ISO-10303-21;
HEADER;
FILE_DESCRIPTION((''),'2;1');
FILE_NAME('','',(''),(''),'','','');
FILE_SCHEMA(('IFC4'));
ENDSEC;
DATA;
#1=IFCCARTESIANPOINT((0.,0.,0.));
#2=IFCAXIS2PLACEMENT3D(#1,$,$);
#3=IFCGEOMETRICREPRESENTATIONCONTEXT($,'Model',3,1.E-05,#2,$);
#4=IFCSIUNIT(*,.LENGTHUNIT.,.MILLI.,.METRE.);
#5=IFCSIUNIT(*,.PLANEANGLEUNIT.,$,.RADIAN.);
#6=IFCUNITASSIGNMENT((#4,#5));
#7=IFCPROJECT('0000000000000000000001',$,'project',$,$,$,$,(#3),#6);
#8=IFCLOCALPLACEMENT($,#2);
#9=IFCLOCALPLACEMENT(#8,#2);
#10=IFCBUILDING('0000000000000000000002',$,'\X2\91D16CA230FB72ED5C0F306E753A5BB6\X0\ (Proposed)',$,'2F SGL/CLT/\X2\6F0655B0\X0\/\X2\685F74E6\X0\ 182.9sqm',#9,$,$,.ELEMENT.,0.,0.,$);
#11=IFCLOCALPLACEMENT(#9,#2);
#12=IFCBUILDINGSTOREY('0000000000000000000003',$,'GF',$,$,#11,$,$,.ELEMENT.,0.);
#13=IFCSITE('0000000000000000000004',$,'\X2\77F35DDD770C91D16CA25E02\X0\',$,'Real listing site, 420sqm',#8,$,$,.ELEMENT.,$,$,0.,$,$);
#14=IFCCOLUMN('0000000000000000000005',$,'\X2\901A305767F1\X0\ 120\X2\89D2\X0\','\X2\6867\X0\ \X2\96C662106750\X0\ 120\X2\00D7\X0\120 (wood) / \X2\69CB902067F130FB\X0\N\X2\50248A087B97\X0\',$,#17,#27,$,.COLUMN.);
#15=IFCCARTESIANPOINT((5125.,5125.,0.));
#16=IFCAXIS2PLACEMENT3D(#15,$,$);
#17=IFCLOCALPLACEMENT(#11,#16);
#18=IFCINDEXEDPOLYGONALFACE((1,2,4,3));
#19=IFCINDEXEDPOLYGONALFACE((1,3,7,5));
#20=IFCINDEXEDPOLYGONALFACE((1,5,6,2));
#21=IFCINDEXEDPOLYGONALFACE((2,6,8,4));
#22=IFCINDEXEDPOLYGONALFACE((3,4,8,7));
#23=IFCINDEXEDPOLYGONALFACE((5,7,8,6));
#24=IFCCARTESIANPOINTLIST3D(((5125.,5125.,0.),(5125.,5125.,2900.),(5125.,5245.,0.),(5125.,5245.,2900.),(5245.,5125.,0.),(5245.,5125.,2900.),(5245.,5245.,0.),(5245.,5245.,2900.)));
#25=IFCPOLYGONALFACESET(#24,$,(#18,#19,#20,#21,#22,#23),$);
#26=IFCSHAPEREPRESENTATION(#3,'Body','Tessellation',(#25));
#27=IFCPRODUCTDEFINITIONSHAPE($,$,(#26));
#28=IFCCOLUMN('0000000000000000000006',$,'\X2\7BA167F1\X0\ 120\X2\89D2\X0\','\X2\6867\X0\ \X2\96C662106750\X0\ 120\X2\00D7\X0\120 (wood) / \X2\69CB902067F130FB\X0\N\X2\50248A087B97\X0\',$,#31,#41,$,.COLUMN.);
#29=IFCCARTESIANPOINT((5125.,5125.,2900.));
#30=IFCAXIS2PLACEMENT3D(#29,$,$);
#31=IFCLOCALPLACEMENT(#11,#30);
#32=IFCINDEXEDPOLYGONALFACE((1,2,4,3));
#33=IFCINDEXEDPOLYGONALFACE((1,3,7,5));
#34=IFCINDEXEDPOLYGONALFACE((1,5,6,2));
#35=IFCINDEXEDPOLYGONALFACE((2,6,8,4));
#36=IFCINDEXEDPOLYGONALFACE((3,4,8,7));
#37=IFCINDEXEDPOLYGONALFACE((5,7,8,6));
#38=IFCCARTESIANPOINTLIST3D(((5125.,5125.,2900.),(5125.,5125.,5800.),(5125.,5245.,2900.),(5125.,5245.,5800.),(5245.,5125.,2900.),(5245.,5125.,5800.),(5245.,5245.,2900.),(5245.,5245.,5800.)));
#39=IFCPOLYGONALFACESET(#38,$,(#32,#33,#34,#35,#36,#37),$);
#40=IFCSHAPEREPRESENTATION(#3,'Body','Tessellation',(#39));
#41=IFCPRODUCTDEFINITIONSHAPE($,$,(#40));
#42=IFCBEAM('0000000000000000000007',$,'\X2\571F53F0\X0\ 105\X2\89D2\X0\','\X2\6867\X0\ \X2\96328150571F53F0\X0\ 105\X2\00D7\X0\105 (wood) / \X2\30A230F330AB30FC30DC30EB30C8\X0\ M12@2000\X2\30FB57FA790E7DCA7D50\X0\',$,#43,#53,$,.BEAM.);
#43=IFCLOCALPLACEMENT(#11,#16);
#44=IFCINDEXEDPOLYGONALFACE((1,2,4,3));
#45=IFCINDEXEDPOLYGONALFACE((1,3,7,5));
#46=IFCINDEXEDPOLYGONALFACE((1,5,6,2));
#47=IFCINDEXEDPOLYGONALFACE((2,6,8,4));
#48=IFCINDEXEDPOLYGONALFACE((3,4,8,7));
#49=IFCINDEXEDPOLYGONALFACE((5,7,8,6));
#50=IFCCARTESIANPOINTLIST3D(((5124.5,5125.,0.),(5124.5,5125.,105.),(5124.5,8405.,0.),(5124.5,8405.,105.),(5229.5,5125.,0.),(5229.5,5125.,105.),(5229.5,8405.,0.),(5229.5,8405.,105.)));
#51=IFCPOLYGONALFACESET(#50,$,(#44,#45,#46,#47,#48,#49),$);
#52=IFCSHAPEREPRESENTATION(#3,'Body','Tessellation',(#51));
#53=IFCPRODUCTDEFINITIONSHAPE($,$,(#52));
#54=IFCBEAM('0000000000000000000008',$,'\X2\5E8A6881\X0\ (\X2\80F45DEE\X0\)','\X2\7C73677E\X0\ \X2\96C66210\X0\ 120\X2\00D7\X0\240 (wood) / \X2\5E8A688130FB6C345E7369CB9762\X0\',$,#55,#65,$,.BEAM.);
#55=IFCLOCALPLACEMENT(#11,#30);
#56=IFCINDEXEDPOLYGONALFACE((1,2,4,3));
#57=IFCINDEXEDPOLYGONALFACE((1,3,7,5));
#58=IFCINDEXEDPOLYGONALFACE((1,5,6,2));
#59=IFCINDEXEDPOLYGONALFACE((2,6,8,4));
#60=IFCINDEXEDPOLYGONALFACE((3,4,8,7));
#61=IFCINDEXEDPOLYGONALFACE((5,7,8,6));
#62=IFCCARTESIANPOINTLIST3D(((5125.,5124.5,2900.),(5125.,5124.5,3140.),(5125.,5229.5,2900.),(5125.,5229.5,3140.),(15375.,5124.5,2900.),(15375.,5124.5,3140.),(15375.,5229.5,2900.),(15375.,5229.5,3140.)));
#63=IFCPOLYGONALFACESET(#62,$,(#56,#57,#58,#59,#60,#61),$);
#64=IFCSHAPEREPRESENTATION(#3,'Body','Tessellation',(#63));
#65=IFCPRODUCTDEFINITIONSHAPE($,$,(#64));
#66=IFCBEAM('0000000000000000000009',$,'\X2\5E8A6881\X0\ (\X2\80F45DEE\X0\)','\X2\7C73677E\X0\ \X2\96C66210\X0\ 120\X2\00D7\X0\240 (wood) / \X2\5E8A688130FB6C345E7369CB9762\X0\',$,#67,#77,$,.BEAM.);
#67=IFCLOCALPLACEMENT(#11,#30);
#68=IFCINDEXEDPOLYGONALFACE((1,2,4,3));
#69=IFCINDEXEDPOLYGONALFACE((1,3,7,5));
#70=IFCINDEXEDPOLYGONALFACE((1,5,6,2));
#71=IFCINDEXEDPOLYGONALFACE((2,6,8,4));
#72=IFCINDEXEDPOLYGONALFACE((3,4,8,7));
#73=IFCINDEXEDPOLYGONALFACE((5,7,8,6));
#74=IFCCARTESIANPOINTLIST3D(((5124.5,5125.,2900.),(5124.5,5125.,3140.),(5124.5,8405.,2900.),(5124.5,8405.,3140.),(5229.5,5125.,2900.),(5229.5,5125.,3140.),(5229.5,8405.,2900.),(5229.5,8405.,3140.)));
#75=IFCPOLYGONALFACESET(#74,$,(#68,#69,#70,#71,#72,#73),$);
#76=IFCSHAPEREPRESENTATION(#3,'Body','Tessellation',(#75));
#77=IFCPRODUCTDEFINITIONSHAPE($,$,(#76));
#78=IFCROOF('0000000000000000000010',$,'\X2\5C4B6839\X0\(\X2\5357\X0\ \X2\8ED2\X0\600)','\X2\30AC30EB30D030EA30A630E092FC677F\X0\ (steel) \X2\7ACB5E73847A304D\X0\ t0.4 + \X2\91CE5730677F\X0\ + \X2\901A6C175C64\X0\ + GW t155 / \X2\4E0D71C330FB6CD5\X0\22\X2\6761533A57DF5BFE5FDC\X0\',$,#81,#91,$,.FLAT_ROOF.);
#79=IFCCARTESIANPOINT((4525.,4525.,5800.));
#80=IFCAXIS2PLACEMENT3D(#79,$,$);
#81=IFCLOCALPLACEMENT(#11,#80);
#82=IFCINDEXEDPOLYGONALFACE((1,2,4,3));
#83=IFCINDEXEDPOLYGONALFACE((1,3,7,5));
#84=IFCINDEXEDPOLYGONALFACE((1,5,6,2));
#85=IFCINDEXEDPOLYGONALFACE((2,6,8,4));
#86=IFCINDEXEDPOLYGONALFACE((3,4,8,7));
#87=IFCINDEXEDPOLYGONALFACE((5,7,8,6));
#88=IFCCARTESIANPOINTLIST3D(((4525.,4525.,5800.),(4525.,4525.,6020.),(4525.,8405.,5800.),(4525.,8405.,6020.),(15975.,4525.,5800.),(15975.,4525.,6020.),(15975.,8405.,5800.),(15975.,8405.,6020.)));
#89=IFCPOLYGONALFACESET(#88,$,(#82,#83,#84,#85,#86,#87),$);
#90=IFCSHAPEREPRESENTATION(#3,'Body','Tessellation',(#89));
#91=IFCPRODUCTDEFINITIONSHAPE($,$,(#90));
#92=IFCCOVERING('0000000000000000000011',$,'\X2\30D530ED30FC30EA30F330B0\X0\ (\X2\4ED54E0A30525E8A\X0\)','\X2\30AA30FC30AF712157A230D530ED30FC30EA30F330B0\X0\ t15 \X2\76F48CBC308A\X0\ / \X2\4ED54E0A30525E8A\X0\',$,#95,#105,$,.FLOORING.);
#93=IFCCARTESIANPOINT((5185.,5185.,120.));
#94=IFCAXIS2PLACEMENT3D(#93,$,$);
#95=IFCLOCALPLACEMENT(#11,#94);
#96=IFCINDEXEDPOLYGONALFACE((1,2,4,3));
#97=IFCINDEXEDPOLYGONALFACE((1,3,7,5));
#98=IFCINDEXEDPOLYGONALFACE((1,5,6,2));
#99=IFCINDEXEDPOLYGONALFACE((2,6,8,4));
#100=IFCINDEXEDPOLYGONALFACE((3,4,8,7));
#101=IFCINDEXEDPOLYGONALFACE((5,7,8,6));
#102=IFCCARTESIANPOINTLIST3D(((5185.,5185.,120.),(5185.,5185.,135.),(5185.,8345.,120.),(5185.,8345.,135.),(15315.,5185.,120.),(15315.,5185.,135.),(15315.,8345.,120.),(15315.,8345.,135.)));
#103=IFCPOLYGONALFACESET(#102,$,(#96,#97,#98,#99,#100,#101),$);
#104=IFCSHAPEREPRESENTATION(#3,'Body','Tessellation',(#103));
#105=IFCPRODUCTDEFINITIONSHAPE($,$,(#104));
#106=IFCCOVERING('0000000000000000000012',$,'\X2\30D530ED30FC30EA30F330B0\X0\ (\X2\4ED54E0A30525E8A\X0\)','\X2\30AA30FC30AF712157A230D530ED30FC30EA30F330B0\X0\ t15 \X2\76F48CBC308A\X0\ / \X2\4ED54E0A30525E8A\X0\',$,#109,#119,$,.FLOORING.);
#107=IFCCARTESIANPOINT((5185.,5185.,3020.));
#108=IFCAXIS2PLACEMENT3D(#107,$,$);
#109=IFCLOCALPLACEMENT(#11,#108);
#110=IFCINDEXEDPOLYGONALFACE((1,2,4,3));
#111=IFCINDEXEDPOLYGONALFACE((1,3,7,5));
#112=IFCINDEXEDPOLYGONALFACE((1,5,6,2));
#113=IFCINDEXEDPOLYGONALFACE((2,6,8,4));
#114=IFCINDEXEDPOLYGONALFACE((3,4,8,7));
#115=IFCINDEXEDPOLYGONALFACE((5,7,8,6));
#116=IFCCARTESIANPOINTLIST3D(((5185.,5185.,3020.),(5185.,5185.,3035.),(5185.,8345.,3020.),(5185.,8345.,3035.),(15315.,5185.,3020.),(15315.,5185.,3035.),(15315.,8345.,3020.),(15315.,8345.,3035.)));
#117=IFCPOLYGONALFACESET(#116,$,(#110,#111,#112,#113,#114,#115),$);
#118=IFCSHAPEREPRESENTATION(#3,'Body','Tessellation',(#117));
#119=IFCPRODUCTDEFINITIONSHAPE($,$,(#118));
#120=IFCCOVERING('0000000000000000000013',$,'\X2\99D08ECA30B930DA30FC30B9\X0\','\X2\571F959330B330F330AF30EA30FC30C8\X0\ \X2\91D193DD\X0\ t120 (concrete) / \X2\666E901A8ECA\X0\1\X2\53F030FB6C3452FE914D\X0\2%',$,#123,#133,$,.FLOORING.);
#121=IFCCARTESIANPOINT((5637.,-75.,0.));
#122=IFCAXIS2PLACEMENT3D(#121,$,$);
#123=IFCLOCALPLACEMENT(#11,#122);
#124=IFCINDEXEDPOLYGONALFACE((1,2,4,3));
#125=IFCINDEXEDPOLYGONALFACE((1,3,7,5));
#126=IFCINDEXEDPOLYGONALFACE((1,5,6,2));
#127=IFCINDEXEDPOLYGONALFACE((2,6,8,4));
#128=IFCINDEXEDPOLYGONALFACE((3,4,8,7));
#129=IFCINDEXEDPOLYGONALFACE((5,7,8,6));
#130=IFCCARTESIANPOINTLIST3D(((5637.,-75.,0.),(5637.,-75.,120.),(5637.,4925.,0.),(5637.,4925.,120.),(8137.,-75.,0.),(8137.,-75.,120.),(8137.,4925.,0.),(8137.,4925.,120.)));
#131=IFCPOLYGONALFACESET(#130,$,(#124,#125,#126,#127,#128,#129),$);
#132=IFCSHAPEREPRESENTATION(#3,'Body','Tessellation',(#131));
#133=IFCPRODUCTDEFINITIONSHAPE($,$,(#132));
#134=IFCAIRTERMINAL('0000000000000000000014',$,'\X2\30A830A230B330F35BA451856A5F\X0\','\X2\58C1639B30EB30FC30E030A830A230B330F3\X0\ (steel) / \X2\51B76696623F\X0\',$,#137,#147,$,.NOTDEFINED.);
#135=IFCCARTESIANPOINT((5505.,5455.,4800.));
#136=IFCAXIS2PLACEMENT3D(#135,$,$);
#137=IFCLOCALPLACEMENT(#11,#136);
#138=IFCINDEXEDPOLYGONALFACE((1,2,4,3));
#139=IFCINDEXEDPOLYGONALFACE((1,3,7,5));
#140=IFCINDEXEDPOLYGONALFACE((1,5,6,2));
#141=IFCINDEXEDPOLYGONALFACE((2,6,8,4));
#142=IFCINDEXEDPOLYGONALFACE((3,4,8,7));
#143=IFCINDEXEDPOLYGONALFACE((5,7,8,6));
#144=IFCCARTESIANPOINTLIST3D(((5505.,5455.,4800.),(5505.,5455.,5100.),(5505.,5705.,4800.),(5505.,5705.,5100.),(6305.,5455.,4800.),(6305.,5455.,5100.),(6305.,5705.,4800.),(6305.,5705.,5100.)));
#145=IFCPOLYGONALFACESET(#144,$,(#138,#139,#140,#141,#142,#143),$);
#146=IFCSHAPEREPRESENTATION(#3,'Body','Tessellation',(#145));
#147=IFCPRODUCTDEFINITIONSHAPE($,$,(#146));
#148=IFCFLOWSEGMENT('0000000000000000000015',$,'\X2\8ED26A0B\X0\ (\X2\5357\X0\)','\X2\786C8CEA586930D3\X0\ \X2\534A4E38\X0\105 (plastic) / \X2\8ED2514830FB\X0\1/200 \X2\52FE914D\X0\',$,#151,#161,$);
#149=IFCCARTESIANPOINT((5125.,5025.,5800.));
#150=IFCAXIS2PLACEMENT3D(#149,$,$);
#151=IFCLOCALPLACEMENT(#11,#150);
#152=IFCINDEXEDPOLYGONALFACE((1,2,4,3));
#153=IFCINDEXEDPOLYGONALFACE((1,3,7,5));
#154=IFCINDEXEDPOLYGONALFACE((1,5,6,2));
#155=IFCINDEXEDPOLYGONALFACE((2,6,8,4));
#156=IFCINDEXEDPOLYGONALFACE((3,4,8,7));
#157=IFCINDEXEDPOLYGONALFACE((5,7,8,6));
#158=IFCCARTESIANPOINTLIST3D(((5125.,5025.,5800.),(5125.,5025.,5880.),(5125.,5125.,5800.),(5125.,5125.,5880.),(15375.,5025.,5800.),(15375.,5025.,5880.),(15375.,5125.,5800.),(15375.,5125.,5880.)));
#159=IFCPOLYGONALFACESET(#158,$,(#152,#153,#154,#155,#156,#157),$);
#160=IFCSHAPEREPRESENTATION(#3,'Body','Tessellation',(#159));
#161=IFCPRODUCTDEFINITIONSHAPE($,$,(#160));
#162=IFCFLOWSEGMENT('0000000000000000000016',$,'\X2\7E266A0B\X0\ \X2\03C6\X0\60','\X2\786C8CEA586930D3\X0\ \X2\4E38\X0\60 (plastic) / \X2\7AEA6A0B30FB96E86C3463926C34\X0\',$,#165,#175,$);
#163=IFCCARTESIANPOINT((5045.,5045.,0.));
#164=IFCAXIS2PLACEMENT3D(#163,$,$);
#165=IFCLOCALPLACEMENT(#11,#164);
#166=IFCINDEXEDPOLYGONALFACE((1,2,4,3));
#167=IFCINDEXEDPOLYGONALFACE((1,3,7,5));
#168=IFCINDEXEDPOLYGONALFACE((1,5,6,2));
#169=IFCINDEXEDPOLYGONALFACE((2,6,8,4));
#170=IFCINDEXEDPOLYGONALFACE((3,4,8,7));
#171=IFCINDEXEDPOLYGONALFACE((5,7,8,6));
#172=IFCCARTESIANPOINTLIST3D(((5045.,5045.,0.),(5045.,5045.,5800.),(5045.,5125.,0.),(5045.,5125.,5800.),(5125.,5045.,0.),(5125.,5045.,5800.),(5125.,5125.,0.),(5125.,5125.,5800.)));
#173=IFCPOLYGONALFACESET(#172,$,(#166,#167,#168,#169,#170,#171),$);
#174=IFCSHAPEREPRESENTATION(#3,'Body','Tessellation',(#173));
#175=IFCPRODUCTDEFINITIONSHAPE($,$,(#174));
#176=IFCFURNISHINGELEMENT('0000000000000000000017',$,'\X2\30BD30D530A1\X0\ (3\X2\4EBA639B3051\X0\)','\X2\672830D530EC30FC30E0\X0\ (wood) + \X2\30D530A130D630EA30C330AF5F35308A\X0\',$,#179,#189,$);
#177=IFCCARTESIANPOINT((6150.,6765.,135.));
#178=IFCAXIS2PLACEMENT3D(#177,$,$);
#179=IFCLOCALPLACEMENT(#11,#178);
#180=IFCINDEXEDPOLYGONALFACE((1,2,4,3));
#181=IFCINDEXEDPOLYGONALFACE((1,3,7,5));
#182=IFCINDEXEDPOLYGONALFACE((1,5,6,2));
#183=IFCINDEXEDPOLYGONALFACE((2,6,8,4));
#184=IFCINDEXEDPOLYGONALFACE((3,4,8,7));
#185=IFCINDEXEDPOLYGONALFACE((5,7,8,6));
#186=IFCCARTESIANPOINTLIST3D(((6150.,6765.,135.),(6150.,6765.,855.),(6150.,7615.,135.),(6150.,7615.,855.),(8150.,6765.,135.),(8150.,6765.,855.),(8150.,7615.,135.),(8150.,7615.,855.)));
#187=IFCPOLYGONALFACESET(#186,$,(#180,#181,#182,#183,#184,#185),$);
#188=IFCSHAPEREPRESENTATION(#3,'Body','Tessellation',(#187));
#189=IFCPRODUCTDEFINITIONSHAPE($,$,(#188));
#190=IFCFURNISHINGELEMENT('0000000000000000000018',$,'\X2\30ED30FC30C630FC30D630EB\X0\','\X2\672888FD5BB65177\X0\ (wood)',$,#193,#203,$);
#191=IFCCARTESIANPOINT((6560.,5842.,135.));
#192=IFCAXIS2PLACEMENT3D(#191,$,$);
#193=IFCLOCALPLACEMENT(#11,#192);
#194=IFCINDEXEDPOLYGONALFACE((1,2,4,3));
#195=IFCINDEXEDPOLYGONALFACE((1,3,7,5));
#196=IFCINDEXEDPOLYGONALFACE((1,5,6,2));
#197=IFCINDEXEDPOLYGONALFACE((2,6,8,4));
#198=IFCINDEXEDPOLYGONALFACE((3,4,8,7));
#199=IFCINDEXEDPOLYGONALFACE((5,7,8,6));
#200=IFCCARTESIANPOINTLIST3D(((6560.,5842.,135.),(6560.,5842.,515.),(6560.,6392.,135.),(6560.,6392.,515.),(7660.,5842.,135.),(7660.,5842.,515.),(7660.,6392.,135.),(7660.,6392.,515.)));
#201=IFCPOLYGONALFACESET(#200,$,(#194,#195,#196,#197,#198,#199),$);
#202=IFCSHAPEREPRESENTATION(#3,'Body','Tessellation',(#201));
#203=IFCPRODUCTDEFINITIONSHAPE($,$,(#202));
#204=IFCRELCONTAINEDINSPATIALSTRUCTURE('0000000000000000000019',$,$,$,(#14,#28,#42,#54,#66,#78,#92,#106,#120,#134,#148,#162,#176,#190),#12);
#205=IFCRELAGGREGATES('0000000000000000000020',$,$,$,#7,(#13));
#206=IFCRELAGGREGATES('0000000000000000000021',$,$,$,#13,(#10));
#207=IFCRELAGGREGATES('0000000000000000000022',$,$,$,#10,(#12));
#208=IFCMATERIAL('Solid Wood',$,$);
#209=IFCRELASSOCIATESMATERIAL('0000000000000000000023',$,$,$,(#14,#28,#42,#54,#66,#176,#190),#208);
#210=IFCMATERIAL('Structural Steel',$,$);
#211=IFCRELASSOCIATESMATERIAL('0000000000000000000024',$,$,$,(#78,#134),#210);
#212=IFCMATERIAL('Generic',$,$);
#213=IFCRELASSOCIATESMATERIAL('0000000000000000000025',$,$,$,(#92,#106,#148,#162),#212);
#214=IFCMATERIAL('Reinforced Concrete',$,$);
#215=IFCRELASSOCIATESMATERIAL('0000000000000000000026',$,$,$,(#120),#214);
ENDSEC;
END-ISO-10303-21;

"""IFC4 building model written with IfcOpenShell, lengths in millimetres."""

from ifc_helpers import new_model, si_unit, frame, frame_2d, origin, place, context, project, spatial, rectangle, extrude, material, element, save


model = new_model("IFC4")

# Units and contexts
model_context = context("Model", 3, precision=1e-05, world=origin())
ifc_project = project(units=[si_unit("LENGTHUNIT", "METRE", prefix="MILLI"), si_unit("PLANEANGLEUNIT", "RADIAN")], contexts=[model_context])

# Site, building, storey
site_placement = place(None, origin())
site = spatial("IfcSite", under=ifc_project, at=site_placement, Name="石川県金沢市", ObjectType="Real listing site, 420sqm", CompositionType="ELEMENT", RefElevation=0.0)
building_placement = place(site_placement, origin())
building = spatial("IfcBuilding", under=site, at=building_placement, Name="金沢・狭小の町家 (Proposed)", ObjectType="2F SGL/CLT/漆喰/桟瓦 182.9sqm", CompositionType="ELEMENT", ElevationOfRefHeight=0.0, ElevationOfTerrain=0.0)
storey_placement = place(building_placement, origin())
storey = spatial("IfcBuildingStorey", under=building, at=storey_placement, Name="GF", CompositionType="ELEMENT", Elevation=0.0)

# Columns
ifc_material_1 = material(Name="Solid Wood")
column_1_placement = place(storey_placement, frame((5125.0, 5125.0, 0.0)))
element("IfcColumn", 1, at=column_1_placement, inside=storey, material=ifc_material_1, Name="通し柱 120角", Description="桧 集成材 120×120 (wood) / 構造柱・N値計算", PredefinedType="COLUMN", context=model_context, shape_type="SweptSolid", body=[
    extrude(rectangle(XDim=120.0, YDim=120.0, at=frame_2d((60.0, 60.0))), frame((5125.0, 5125.0, 0.0)), (0.0, 0.0, 1.0), 2900.0),
])
column_2_placement = place(storey_placement, frame((5125.0, 5125.0, 2900.0)))
element("IfcColumn", 2, at=column_2_placement, inside=storey, material=ifc_material_1, Name="管柱 120角", Description="桧 集成材 120×120 (wood) / 構造柱・N値計算", PredefinedType="COLUMN", context=model_context, shape_type="SweptSolid", body=[
    extrude(rectangle(XDim=120.0, YDim=120.0, at=frame_2d((60.0, 60.0))), frame((5125.0, 5125.0, 2900.0)), (0.0, 0.0, 1.0), 2900.0),
])

# Beams
beam_1_placement = place(storey_placement, frame((5125.0, 5125.0, 0.0)))
element("IfcBeam", 3, at=beam_1_placement, inside=storey, material=ifc_material_1, Name="土台 105角", Description="桧 防腐土台 105×105 (wood) / アンカーボルト M12@2000・基礎緊結", PredefinedType="BEAM", context=model_context, shape_type="SweptSolid", body=[
    extrude(rectangle(XDim=105.0, YDim=3280.0, at=frame_2d((52.0, 1640.0))), frame((5125.0, 5125.0, 0.0)), (0.0, 0.0, 1.0), 105.0),
])
beam_2_placement = place(storey_placement, frame((5125.0, 5125.0, 2900.0)))
element("IfcBeam", 4, at=beam_2_placement, inside=storey, material=ifc_material_1, Name="床梁 (胴差)", Description="米松 集成 120×240 (wood) / 床梁・水平構面", PredefinedType="BEAM", context=model_context, shape_type="SweptSolid", body=[
    extrude(rectangle(XDim=10250.0, YDim=105.0, at=frame_2d((5125.0, 52.0))), frame((5125.0, 5125.0, 2900.0)), (0.0, 0.0, 1.0), 240.0),
])
beam_3_placement = place(storey_placement, frame((5125.0, 5125.0, 2900.0)))
element("IfcBeam", 5, at=beam_3_placement, inside=storey, material=ifc_material_1, Name="床梁 (胴差)", Description="米松 集成 120×240 (wood) / 床梁・水平構面", PredefinedType="BEAM", context=model_context, shape_type="SweptSolid", body=[
    extrude(rectangle(XDim=105.0, YDim=3280.0, at=frame_2d((52.0, 1640.0))), frame((5125.0, 5125.0, 2900.0)), (0.0, 0.0, 1.0), 240.0),
])

# Shared definitions
ifc_material_2 = material(Name="Reinforced Concrete")

# Roof
ifc_material_3 = material(Name="Structural Steel")
for number, where, name in (
    (6, (4525.0, 4525.0, 5800.0), "屋根(南 軒600)"),
):
    element("IfcRoof", number, at=place(storey_placement, frame(where)), inside=storey, material=ifc_material_3, Name=name, Description="ガルバリウム鋼板 (steel) 立平葺き t0.4 + 野地板 + 通気層 + GW t155 / 不燃・法22条区域対応", PredefinedType="FLAT_ROOF", context=model_context, shape_type="SweptSolid", body=[
        extrude(rectangle(XDim=11450.0, YDim=3880.0, at=frame_2d((5725.0, 1940.0))), frame((4525.0, 4525.0, 5800.0)), (0.0, 0.0, 1.0), 220.0),
    ])

# Coverings
ifc_material_4 = material(Name="Generic")
covering_1_placement = place(storey_placement, frame((5185.0, 5185.0, 120.0)))
element("IfcCovering", 7, at=covering_1_placement, inside=storey, material=ifc_material_4, Name="フローリング (仕上げ床)", Description="オーク無垢フローリング t15 直貼り / 仕上げ床", PredefinedType="FLOORING", context=model_context, shape_type="SweptSolid", body=[
    extrude(rectangle(XDim=10130.0, YDim=3160.0, at=frame_2d((5065.0, 1580.0))), frame((5185.0, 5185.0, 120.0)), (0.0, 0.0, 1.0), 15.0),
])
covering_2_placement = place(storey_placement, frame((5185.0, 5185.0, 3020.0)))
element("IfcCovering", 8, at=covering_2_placement, inside=storey, material=ifc_material_4, Name="フローリング (仕上げ床)", Description="オーク無垢フローリング t15 直貼り / 仕上げ床", PredefinedType="FLOORING", context=model_context, shape_type="SweptSolid", body=[
    extrude(rectangle(XDim=10130.0, YDim=3160.0, at=frame_2d((5065.0, 1580.0))), frame((5185.0, 5185.0, 3020.0)), (0.0, 0.0, 1.0), 15.0),
])
covering_3_placement = place(storey_placement, frame((5637.0, -75.0, 0.0)))
element("IfcCovering", 9, at=covering_3_placement, inside=storey, material=ifc_material_2, Name="駐車スペース", Description="土間コンクリート 金鏝 t120 (concrete) / 普通車1台・水勾配2%", PredefinedType="FLOORING", context=model_context, shape_type="SweptSolid", body=[
    extrude(rectangle(XDim=2500.0, YDim=5000.0, at=frame_2d((1250.0, 2500.0))), frame((5637.0, -75.0, 0.0)), (0.0, 0.0, 1.0), 120.0),
])

# Air terminal
air_terminal_placement = place(storey_placement, frame((5505.0, 5455.0, 4800.0)))
element("IfcAirTerminal", 10, at=air_terminal_placement, inside=storey, material=ifc_material_3, Name="エアコン室内機", Description="壁掛ルームエアコン (steel) / 冷暖房", PredefinedType="NOTDEFINED", context=model_context, shape_type="SweptSolid", body=[
    extrude(rectangle(XDim=800.0, YDim=250.0, at=frame_2d((400.0, 125.0))), frame((5505.0, 5455.0, 4800.0)), (0.0, 0.0, 1.0), 300.0),
])

# Flow segments
flow_segment_1_placement = place(storey_placement, frame((5125.0, 5025.0, 5800.0)))
element("IfcFlowSegment", 11, at=flow_segment_1_placement, inside=storey, material=ifc_material_4, Name="軒樋 (南)", Description="硬質塩ビ 半丸105 (plastic) / 軒先・1/200 勾配", context=model_context, shape_type="SweptSolid", body=[
    extrude(rectangle(XDim=10250.0, YDim=100.0, at=frame_2d((5125.0, 50.0))), frame((5125.0, 5025.0, 5800.0)), (0.0, 0.0, 1.0), 80.0),
])
flow_segment_2_placement = place(storey_placement, frame((5045.0, 5045.0, 0.0)))
element("IfcFlowSegment", 12, at=flow_segment_2_placement, inside=storey, material=ifc_material_4, Name="縦樋 φ60", Description="硬質塩ビ 丸60 (plastic) / 竪樋・雨水排水", context=model_context, shape_type="SweptSolid", body=[
    extrude(rectangle(XDim=80.0, YDim=80.0, at=frame_2d((40.0, 40.0))), frame((5045.0, 5045.0, 0.0)), (0.0, 0.0, 1.0), 5800.0),
])

# Furnishing elements
furnishing_1_placement = place(storey_placement, frame((6150.0, 6765.0, 135.0)))
element("IfcFurnishingElement", 13, at=furnishing_1_placement, inside=storey, material=ifc_material_1, Name="ソファ (3人掛け)", Description="木フレーム (wood) + ファブリック張り", context=model_context, shape_type="SweptSolid", body=[
    extrude(rectangle(XDim=2000.0, YDim=850.0, at=frame_2d((1000.0, 425.0))), frame((6150.0, 6765.0, 135.0)), (0.0, 0.0, 1.0), 720.0),
])
furnishing_2_placement = place(storey_placement, frame((6560.0, 5842.0, 135.0)))
element("IfcFurnishingElement", 14, at=furnishing_2_placement, inside=storey, material=ifc_material_1, Name="ローテーブル", Description="木製家具 (wood)", context=model_context, shape_type="SweptSolid", body=[
    extrude(rectangle(XDim=1100.0, YDim=550.0, at=frame_2d((550.0, 275.0))), frame((6560.0, 5842.0, 135.0)), (0.0, 0.0, 1.0), 380.0),
])

save(model, "model.ifc")
